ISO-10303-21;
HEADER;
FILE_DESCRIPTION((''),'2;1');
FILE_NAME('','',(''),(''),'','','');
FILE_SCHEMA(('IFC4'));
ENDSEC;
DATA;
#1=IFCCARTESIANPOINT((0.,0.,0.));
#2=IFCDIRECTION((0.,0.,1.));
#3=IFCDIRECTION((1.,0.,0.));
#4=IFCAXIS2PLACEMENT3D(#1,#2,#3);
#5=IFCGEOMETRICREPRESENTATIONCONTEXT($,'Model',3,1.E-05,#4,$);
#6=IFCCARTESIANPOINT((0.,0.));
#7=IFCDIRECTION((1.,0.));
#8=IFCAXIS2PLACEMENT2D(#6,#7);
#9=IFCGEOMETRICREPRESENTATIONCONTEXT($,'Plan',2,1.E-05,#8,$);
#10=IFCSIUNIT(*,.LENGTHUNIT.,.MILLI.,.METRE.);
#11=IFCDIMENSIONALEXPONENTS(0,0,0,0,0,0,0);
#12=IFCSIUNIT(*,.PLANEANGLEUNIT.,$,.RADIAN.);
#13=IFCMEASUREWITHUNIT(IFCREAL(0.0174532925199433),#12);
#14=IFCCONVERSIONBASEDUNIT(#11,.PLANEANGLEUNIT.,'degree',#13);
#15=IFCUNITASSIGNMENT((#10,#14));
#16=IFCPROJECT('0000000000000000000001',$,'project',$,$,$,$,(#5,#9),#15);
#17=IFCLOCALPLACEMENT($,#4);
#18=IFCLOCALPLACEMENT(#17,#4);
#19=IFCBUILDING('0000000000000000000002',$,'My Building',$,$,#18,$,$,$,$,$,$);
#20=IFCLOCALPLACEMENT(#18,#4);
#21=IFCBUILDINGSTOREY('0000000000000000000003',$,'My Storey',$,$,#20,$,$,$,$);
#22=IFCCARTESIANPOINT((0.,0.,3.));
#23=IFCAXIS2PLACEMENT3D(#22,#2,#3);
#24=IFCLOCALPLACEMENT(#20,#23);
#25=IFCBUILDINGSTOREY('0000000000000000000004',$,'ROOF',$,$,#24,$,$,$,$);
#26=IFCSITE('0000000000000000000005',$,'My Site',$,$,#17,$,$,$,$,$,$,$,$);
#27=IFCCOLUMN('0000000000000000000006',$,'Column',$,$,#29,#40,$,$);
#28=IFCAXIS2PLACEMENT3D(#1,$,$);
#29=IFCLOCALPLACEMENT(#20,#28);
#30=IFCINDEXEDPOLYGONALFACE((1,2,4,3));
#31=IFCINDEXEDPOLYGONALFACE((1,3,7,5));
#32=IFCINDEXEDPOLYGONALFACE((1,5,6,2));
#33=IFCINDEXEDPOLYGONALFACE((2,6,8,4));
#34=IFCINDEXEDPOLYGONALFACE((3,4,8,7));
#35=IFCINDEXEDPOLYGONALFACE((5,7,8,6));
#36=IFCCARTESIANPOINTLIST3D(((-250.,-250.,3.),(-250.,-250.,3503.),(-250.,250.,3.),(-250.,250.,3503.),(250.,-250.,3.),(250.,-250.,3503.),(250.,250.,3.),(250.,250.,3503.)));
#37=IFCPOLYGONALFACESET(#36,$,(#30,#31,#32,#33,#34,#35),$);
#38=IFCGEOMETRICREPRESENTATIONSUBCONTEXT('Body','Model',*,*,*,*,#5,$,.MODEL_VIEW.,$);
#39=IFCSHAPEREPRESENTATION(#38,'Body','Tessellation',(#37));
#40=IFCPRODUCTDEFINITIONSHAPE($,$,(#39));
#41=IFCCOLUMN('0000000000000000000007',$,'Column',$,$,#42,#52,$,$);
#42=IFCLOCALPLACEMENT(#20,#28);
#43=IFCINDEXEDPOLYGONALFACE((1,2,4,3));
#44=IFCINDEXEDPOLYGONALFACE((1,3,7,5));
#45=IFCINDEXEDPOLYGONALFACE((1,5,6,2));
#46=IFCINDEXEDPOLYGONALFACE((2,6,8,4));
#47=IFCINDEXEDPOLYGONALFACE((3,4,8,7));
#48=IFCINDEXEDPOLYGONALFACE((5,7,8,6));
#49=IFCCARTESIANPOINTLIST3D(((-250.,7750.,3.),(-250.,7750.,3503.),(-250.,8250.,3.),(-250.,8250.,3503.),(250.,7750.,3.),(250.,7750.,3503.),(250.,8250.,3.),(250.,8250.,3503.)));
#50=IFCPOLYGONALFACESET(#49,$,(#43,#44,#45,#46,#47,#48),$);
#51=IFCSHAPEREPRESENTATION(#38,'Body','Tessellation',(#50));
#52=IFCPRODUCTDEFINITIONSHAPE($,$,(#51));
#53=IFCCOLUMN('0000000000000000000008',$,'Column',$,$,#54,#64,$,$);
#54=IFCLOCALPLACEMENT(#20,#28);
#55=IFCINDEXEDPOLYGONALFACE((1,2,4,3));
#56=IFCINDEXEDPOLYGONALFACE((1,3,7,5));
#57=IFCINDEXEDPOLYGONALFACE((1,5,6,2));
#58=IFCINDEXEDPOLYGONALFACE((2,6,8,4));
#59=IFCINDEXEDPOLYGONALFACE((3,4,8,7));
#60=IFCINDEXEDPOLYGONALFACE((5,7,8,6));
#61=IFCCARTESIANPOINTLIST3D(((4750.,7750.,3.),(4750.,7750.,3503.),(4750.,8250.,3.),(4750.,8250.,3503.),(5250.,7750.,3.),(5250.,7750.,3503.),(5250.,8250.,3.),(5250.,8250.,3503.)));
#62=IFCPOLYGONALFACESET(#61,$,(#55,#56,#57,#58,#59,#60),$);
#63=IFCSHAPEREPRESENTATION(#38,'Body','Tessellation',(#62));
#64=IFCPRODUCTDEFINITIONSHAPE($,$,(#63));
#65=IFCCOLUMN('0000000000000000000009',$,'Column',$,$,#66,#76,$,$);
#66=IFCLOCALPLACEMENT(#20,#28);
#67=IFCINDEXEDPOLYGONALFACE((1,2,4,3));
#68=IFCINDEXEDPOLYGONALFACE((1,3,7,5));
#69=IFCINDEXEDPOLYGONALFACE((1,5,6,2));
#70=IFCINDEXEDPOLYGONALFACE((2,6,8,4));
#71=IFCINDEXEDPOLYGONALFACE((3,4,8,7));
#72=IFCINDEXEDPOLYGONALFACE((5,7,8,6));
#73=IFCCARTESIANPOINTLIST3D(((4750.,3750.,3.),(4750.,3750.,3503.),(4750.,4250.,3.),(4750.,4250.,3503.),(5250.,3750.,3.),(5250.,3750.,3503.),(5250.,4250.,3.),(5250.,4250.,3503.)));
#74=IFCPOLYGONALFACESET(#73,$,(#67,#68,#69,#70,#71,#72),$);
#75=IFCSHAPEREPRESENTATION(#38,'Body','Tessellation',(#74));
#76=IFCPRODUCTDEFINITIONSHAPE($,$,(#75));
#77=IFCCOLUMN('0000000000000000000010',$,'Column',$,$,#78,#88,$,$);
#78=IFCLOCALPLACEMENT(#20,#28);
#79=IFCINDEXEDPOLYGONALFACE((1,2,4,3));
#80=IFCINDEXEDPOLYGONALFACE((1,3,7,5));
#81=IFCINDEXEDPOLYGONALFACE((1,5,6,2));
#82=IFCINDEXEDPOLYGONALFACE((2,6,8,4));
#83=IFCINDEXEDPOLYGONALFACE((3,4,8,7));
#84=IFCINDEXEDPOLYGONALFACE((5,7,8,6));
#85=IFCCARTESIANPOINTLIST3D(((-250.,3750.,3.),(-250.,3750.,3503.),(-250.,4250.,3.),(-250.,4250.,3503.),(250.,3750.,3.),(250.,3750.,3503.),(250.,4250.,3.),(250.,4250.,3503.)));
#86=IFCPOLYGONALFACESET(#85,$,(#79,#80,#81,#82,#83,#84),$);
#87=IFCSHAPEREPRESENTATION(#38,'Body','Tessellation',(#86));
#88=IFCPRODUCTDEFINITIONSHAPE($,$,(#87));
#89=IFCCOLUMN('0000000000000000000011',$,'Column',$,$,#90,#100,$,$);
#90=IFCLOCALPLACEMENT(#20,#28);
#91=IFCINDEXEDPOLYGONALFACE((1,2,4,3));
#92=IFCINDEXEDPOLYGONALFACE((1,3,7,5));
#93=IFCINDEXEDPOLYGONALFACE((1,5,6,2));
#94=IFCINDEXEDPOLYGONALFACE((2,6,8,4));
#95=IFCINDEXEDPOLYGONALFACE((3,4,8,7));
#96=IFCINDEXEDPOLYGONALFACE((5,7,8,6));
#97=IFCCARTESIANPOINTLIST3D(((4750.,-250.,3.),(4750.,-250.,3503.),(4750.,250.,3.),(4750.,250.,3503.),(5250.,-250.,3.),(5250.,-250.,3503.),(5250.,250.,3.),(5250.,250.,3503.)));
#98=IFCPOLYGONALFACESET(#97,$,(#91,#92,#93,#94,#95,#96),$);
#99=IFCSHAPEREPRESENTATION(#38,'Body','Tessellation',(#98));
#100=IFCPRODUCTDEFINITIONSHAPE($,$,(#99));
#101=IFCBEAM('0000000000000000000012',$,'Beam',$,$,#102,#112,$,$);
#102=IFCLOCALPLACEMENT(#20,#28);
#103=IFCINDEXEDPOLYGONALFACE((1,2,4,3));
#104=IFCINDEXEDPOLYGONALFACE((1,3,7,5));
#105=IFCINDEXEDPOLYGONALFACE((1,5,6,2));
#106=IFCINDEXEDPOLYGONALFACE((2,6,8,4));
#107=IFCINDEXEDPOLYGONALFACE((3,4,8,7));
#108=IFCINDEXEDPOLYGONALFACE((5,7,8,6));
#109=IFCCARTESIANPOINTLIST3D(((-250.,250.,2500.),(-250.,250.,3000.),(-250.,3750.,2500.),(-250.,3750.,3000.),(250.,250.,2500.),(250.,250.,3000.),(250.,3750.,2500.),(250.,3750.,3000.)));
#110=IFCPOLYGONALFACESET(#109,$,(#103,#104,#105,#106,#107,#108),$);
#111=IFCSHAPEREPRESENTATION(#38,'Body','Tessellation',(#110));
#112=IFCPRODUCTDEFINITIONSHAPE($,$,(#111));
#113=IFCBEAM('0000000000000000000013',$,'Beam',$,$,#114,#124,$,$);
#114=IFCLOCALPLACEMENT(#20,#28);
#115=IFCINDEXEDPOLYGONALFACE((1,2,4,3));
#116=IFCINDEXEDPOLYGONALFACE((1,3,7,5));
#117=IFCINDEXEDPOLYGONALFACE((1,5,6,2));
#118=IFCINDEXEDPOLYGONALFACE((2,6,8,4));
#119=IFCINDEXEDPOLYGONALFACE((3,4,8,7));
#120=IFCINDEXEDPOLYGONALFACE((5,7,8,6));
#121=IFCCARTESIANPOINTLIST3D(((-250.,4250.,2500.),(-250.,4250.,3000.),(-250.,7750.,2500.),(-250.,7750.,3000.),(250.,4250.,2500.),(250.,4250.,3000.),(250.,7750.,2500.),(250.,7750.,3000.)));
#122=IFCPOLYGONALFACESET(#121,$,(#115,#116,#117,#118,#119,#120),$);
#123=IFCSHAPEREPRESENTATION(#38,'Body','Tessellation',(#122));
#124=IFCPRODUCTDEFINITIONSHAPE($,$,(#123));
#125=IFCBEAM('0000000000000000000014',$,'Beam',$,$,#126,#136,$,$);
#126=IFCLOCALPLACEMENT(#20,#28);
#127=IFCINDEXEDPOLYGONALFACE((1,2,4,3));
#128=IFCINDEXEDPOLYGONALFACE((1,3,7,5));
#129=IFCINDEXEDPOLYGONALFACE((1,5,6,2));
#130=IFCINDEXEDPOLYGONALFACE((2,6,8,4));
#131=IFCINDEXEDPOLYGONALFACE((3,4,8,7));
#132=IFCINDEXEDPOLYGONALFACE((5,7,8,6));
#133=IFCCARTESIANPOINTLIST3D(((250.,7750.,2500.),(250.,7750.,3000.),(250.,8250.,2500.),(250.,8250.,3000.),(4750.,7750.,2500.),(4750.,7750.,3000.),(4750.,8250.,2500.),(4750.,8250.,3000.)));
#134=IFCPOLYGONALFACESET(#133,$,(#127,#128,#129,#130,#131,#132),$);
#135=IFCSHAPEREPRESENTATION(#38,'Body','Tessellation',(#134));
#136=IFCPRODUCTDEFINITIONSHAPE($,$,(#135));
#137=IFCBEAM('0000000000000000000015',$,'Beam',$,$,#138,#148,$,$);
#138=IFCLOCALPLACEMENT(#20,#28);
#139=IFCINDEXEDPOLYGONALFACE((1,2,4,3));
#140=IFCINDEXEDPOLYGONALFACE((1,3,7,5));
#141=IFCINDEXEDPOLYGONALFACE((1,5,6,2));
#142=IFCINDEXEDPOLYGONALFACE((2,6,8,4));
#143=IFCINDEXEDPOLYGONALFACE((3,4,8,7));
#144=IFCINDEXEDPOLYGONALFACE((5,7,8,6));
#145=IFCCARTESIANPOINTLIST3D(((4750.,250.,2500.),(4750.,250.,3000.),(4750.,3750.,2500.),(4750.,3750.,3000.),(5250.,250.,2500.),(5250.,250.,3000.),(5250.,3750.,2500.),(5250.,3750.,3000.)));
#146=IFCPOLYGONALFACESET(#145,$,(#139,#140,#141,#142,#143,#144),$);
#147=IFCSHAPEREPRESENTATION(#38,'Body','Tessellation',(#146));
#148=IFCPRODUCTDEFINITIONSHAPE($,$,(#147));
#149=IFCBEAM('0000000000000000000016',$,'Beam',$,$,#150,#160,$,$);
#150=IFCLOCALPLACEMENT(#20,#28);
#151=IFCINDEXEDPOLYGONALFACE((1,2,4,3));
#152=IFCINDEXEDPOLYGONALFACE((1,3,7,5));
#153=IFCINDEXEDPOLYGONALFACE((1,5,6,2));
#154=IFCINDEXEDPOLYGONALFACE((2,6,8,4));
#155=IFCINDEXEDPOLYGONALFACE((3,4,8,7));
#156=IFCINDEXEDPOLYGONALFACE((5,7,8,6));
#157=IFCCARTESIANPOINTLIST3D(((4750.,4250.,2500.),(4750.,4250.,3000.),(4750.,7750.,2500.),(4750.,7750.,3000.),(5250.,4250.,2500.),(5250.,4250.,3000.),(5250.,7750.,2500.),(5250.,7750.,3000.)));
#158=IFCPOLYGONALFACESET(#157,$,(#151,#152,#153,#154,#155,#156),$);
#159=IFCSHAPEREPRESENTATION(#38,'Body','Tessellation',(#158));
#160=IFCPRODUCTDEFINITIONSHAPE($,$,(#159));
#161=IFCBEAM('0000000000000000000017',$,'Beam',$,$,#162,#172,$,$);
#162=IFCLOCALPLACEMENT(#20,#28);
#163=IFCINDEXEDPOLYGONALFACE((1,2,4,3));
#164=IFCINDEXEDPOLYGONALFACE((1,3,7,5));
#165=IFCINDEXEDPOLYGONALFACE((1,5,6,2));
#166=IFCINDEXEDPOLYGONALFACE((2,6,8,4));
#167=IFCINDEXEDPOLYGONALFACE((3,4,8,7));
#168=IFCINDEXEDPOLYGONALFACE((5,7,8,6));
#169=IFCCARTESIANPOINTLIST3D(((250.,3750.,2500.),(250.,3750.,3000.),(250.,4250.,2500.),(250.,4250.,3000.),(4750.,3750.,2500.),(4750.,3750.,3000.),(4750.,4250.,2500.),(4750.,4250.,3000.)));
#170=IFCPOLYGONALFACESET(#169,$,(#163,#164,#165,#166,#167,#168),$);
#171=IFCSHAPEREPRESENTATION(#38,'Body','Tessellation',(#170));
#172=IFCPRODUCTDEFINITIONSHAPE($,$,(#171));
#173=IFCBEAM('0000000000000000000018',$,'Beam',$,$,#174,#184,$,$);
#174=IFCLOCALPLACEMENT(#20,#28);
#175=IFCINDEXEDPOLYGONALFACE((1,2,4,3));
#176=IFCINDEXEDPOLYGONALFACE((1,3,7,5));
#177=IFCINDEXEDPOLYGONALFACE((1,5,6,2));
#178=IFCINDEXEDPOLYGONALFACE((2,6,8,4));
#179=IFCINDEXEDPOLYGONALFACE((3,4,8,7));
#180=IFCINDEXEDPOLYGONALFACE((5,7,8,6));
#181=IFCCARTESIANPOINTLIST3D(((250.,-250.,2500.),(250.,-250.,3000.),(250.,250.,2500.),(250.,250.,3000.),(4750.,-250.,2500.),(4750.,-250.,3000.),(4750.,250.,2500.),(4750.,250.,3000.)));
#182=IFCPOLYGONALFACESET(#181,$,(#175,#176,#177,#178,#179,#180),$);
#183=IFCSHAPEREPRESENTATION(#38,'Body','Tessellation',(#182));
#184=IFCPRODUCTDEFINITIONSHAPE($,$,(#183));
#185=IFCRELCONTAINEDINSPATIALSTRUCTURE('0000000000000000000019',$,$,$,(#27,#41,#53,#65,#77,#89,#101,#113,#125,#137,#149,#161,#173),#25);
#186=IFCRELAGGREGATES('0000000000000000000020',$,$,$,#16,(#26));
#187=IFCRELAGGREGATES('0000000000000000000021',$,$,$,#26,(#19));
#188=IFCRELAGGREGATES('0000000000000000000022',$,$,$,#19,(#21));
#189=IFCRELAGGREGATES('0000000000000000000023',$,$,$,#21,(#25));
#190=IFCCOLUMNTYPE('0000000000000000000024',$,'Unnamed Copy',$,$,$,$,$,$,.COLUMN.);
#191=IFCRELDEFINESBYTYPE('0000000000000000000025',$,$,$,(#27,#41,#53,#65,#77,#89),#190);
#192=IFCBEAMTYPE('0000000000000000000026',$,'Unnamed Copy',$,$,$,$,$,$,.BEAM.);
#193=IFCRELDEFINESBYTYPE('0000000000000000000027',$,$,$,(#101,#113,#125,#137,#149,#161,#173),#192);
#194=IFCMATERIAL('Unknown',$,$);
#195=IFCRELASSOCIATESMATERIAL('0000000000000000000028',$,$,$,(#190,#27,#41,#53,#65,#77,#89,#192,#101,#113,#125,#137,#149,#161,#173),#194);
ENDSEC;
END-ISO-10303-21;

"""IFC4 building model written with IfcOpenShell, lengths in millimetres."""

from ifc_helpers import new_model, entity, si_unit, converted_unit, frame, origin_with_axes, origin_2d_with_axis, place, context, subcontext, project, spatial, rectangle, extrude, material, material_profile, profile_set, profile_usage, type_object, element, save


model = new_model("IFC4")

# Units and contexts
model_context = context("Model", 3, precision=1e-05, world=origin_with_axes())
plan_context = context("Plan", 2, precision=1e-05, world=origin_2d_with_axis())
body_context = subcontext(model_context, "Body", "Model", "MODEL_VIEW")
ifc_project = project(units=[si_unit("LENGTHUNIT", "METRE", prefix="MILLI"), converted_unit("PLANEANGLEUNIT", "degree", entity("IfcReal", 0.0174532925199433), si_unit("PLANEANGLEUNIT", "RADIAN"), dimensions=[0, 0, 0, 0, 0, 0, 0])], contexts=[model_context, plan_context])

# Site, building, storeys
site_placement = place(None, origin_with_axes())
site = spatial("IfcSite", under=ifc_project, at=site_placement, Name="My Site")
building_placement = place(site_placement, origin_with_axes())
building = spatial("IfcBuilding", under=site, at=building_placement, Name="My Building")
storey_1_placement = place(building_placement, origin_with_axes())
storey_1 = spatial("IfcBuildingStorey", under=building, at=storey_1_placement, Name="My Storey")
storey_2_placement = place(storey_1_placement, frame((0.0, 0.0, 3.0), z_axis=(0.0, 0.0, 1.0), x_axis=(1.0, 0.0, 0.0)))
storey_2 = spatial("IfcBuildingStorey", under=storey_1, at=storey_2_placement, Name="ROOF")

# Columns
ifc_material = material(Name="Unknown")
ifc_material_profile_1 = material_profile(ifc_material, rectangle(XDim=500.0, YDim=500.0))
ifc_profile_set_1 = profile_set([ifc_material_profile_1])
ifc_profile_usage_1 = profile_usage(ifc_profile_set_1, cardinal=10)
column_type = type_object("IfcColumnType", Name="Unnamed Copy", PredefinedType="COLUMN", material=ifc_profile_set_1)
column_1_placement = place(storey_2_placement, origin_with_axes())
element("IfcColumn", 1, at=column_1_placement, inside=storey_2, type_object=column_type, material=ifc_profile_usage_1, Name="Column", context=body_context, shape_type="SweptSolid", body=[
    extrude(rectangle(XDim=500.0, YDim=500.0), origin_with_axes(), (0.0, 0.0, 1.0), 3500.0),
])
ifc_profile_usage_2 = profile_usage(ifc_profile_set_1, cardinal=10)
column_2_placement = place(storey_2_placement, frame((0.0, 8000.0, 0.0), z_axis=(0.0, 0.0, 1.0), x_axis=(1.0, 0.0, 0.0)))
element("IfcColumn", 2, at=column_2_placement, inside=storey_2, type_object=column_type, material=ifc_profile_usage_2, Name="Column", context=body_context, shape_type="SweptSolid", body=[
    extrude(rectangle(XDim=500.0, YDim=500.0), origin_with_axes(), (0.0, 0.0, 1.0), 3500.0),
])
ifc_profile_usage_3 = profile_usage(ifc_profile_set_1, cardinal=10)
column_3_placement = place(storey_2_placement, frame((5000.0, 8000.0, 0.0), z_axis=(0.0, 0.0, 1.0), x_axis=(1.0, 0.0, 0.0)))
element("IfcColumn", 3, at=column_3_placement, inside=storey_2, type_object=column_type, material=ifc_profile_usage_3, Name="Column", context=body_context, shape_type="SweptSolid", body=[
    extrude(rectangle(XDim=500.0, YDim=500.0), origin_with_axes(), (0.0, 0.0, 1.0), 3500.0),
])
ifc_profile_usage_4 = profile_usage(ifc_profile_set_1, cardinal=10)
column_4_placement = place(storey_2_placement, frame((5000.0, 4000.0, 0.0), z_axis=(0.0, 0.0, 1.0), x_axis=(1.0, 0.0, 0.0)))
element("IfcColumn", 4, at=column_4_placement, inside=storey_2, type_object=column_type, material=ifc_profile_usage_4, Name="Column", context=body_context, shape_type="SweptSolid", body=[
    extrude(rectangle(XDim=500.0, YDim=500.0), origin_with_axes(), (0.0, 0.0, 1.0), 3500.0),
])
ifc_profile_usage_5 = profile_usage(ifc_profile_set_1, cardinal=10)
column_5_placement = place(storey_2_placement, frame((0.0, 4000.0, 0.0), z_axis=(0.0, 0.0, 1.0), x_axis=(1.0, 0.0, 0.0)))
element("IfcColumn", 5, at=column_5_placement, inside=storey_2, type_object=column_type, material=ifc_profile_usage_5, Name="Column", context=body_context, shape_type="SweptSolid", body=[
    extrude(rectangle(XDim=500.0, YDim=500.0), origin_with_axes(), (0.0, 0.0, 1.0), 3500.0),
])
ifc_profile_usage_6 = profile_usage(ifc_profile_set_1, cardinal=10)
column_6_placement = place(storey_2_placement, frame((5000.0, 0.0, 0.0), z_axis=(0.0, 0.0, 1.0), x_axis=(1.0, 0.0, 0.0)))
element("IfcColumn", 6, at=column_6_placement, inside=storey_2, type_object=column_type, material=ifc_profile_usage_6, Name="Column", context=body_context, shape_type="SweptSolid", body=[
    extrude(rectangle(XDim=500.0, YDim=500.0), origin_with_axes(), (0.0, 0.0, 1.0), 3500.0),
])

# Beams
ifc_material_profile_2 = material_profile(ifc_material, rectangle(XDim=500.0, YDim=500.0))
ifc_profile_set_2 = profile_set([ifc_material_profile_2])
ifc_profile_usage_7 = profile_usage(ifc_profile_set_2, cardinal=7)
beam_type = type_object("IfcBeamType", Name="Unnamed Copy", PredefinedType="BEAM", material=ifc_profile_set_2)
beam_1_placement = place(storey_2_placement, frame((-250.0, 250.0, 2997.0), z_axis=(0.0, 1.0, 0.0), x_axis=(-1.0, 0.0, 0.0)))
element("IfcBeam", 7, at=beam_1_placement, inside=storey_2, type_object=beam_type, material=ifc_profile_usage_7, Name="Beam", context=body_context, shape_type="SweptSolid", body=[
    extrude(rectangle(XDim=500.0, YDim=500.0), frame((-250.0, -250.0, 0.0), z_axis=(0.0, 0.0, 1.0), x_axis=(1.0, 0.0, 0.0)), (0.0, 0.0, 1.0), 3500.0),
])
ifc_profile_usage_8 = profile_usage(ifc_profile_set_2, cardinal=7)
beam_2_placement = place(storey_2_placement, frame((-250.0, 4250.0, 2997.0), z_axis=(0.0, 1.0, 0.0), x_axis=(-1.0, 0.0, 0.0)))
element("IfcBeam", 8, at=beam_2_placement, inside=storey_2, type_object=beam_type, material=ifc_profile_usage_8, Name="Beam", context=body_context, shape_type="SweptSolid", body=[
    extrude(rectangle(XDim=500.0, YDim=500.0), frame((-250.0, -250.0, 0.0), z_axis=(0.0, 0.0, 1.0), x_axis=(1.0, 0.0, 0.0)), (0.0, 0.0, 1.0), 3500.0),
])
ifc_profile_usage_9 = profile_usage(ifc_profile_set_2, cardinal=7)
beam_3_placement = place(storey_2_placement, frame((250.0, 8250.0, 2997.0), z_axis=(1.0, -0.000001, 0.000001), x_axis=(0.000001, 1.0, 0.0)))
element("IfcBeam", 9, at=beam_3_placement, inside=storey_2, type_object=beam_type, material=ifc_profile_usage_9, Name="Beam", context=body_context, shape_type="SweptSolid", body=[
    extrude(rectangle(XDim=500.0, YDim=500.0), frame((-250.0, -250.0, 0.0), z_axis=(0.0, 0.0, 1.0), x_axis=(1.0, 0.0, 0.0)), (0.0, 0.0, 1.0), 4500.0),
])
ifc_profile_usage_10 = profile_usage(ifc_profile_set_2, cardinal=7)
beam_4_placement = place(storey_2_placement, frame((4750.0, 250.0, 2997.0), z_axis=(0.0, 1.0, 0.0), x_axis=(-1.0, 0.0, 0.0)))
element("IfcBeam", 10, at=beam_4_placement, inside=storey_2, type_object=beam_type, material=ifc_profile_usage_10, Name="Beam", context=body_context, shape_type="SweptSolid", body=[
    extrude(rectangle(XDim=500.0, YDim=500.0), frame((-250.0, -250.0, 0.0), z_axis=(0.0, 0.0, 1.0), x_axis=(1.0, 0.0, 0.0)), (0.0, 0.0, 1.0), 3500.0),
])
ifc_profile_usage_11 = profile_usage(ifc_profile_set_2, cardinal=7)
beam_5_placement = place(storey_2_placement, frame((4750.0, 4250.0, 2997.0), z_axis=(0.0, 1.0, 0.0), x_axis=(-1.0, 0.0, 0.0)))
element("IfcBeam", 11, at=beam_5_placement, inside=storey_2, type_object=beam_type, material=ifc_profile_usage_11, Name="Beam", context=body_context, shape_type="SweptSolid", body=[
    extrude(rectangle(XDim=500.0, YDim=500.0), frame((-250.0, -250.0, 0.0), z_axis=(0.0, 0.0, 1.0), x_axis=(1.0, 0.0, 0.0)), (0.0, 0.0, 1.0), 3500.0),
])
ifc_profile_usage_12 = profile_usage(ifc_profile_set_2, cardinal=7)
beam_6_placement = place(storey_2_placement, frame((250.0, 4250.0, 2997.0), z_axis=(1.0, -0.000001, 0.000001), x_axis=(0.000001, 1.0, 0.0)))
element("IfcBeam", 12, at=beam_6_placement, inside=storey_2, type_object=beam_type, material=ifc_profile_usage_12, Name="Beam", context=body_context, shape_type="SweptSolid", body=[
    extrude(rectangle(XDim=500.0, YDim=500.0), frame((-250.0, -250.0, 0.0), z_axis=(0.0, 0.0, 1.0), x_axis=(1.0, 0.0, 0.0)), (0.0, 0.0, 1.0), 4500.0),
])
ifc_profile_usage_13 = profile_usage(ifc_profile_set_2, cardinal=7)
beam_7_placement = place(storey_2_placement, frame((250.0, 250.0, 2997.0), z_axis=(1.0, -0.000001, 0.000001), x_axis=(0.000001, 1.0, 0.0)))
element("IfcBeam", 13, at=beam_7_placement, inside=storey_2, type_object=beam_type, material=ifc_profile_usage_13, Name="Beam", context=body_context, shape_type="SweptSolid", body=[
    extrude(rectangle(XDim=500.0, YDim=500.0), frame((-250.0, -250.0, 0.0), z_axis=(0.0, 0.0, 1.0), x_axis=(1.0, 0.0, 0.0)), (0.0, 0.0, 1.0), 4500.0),
])

save(model, "model.ifc")
